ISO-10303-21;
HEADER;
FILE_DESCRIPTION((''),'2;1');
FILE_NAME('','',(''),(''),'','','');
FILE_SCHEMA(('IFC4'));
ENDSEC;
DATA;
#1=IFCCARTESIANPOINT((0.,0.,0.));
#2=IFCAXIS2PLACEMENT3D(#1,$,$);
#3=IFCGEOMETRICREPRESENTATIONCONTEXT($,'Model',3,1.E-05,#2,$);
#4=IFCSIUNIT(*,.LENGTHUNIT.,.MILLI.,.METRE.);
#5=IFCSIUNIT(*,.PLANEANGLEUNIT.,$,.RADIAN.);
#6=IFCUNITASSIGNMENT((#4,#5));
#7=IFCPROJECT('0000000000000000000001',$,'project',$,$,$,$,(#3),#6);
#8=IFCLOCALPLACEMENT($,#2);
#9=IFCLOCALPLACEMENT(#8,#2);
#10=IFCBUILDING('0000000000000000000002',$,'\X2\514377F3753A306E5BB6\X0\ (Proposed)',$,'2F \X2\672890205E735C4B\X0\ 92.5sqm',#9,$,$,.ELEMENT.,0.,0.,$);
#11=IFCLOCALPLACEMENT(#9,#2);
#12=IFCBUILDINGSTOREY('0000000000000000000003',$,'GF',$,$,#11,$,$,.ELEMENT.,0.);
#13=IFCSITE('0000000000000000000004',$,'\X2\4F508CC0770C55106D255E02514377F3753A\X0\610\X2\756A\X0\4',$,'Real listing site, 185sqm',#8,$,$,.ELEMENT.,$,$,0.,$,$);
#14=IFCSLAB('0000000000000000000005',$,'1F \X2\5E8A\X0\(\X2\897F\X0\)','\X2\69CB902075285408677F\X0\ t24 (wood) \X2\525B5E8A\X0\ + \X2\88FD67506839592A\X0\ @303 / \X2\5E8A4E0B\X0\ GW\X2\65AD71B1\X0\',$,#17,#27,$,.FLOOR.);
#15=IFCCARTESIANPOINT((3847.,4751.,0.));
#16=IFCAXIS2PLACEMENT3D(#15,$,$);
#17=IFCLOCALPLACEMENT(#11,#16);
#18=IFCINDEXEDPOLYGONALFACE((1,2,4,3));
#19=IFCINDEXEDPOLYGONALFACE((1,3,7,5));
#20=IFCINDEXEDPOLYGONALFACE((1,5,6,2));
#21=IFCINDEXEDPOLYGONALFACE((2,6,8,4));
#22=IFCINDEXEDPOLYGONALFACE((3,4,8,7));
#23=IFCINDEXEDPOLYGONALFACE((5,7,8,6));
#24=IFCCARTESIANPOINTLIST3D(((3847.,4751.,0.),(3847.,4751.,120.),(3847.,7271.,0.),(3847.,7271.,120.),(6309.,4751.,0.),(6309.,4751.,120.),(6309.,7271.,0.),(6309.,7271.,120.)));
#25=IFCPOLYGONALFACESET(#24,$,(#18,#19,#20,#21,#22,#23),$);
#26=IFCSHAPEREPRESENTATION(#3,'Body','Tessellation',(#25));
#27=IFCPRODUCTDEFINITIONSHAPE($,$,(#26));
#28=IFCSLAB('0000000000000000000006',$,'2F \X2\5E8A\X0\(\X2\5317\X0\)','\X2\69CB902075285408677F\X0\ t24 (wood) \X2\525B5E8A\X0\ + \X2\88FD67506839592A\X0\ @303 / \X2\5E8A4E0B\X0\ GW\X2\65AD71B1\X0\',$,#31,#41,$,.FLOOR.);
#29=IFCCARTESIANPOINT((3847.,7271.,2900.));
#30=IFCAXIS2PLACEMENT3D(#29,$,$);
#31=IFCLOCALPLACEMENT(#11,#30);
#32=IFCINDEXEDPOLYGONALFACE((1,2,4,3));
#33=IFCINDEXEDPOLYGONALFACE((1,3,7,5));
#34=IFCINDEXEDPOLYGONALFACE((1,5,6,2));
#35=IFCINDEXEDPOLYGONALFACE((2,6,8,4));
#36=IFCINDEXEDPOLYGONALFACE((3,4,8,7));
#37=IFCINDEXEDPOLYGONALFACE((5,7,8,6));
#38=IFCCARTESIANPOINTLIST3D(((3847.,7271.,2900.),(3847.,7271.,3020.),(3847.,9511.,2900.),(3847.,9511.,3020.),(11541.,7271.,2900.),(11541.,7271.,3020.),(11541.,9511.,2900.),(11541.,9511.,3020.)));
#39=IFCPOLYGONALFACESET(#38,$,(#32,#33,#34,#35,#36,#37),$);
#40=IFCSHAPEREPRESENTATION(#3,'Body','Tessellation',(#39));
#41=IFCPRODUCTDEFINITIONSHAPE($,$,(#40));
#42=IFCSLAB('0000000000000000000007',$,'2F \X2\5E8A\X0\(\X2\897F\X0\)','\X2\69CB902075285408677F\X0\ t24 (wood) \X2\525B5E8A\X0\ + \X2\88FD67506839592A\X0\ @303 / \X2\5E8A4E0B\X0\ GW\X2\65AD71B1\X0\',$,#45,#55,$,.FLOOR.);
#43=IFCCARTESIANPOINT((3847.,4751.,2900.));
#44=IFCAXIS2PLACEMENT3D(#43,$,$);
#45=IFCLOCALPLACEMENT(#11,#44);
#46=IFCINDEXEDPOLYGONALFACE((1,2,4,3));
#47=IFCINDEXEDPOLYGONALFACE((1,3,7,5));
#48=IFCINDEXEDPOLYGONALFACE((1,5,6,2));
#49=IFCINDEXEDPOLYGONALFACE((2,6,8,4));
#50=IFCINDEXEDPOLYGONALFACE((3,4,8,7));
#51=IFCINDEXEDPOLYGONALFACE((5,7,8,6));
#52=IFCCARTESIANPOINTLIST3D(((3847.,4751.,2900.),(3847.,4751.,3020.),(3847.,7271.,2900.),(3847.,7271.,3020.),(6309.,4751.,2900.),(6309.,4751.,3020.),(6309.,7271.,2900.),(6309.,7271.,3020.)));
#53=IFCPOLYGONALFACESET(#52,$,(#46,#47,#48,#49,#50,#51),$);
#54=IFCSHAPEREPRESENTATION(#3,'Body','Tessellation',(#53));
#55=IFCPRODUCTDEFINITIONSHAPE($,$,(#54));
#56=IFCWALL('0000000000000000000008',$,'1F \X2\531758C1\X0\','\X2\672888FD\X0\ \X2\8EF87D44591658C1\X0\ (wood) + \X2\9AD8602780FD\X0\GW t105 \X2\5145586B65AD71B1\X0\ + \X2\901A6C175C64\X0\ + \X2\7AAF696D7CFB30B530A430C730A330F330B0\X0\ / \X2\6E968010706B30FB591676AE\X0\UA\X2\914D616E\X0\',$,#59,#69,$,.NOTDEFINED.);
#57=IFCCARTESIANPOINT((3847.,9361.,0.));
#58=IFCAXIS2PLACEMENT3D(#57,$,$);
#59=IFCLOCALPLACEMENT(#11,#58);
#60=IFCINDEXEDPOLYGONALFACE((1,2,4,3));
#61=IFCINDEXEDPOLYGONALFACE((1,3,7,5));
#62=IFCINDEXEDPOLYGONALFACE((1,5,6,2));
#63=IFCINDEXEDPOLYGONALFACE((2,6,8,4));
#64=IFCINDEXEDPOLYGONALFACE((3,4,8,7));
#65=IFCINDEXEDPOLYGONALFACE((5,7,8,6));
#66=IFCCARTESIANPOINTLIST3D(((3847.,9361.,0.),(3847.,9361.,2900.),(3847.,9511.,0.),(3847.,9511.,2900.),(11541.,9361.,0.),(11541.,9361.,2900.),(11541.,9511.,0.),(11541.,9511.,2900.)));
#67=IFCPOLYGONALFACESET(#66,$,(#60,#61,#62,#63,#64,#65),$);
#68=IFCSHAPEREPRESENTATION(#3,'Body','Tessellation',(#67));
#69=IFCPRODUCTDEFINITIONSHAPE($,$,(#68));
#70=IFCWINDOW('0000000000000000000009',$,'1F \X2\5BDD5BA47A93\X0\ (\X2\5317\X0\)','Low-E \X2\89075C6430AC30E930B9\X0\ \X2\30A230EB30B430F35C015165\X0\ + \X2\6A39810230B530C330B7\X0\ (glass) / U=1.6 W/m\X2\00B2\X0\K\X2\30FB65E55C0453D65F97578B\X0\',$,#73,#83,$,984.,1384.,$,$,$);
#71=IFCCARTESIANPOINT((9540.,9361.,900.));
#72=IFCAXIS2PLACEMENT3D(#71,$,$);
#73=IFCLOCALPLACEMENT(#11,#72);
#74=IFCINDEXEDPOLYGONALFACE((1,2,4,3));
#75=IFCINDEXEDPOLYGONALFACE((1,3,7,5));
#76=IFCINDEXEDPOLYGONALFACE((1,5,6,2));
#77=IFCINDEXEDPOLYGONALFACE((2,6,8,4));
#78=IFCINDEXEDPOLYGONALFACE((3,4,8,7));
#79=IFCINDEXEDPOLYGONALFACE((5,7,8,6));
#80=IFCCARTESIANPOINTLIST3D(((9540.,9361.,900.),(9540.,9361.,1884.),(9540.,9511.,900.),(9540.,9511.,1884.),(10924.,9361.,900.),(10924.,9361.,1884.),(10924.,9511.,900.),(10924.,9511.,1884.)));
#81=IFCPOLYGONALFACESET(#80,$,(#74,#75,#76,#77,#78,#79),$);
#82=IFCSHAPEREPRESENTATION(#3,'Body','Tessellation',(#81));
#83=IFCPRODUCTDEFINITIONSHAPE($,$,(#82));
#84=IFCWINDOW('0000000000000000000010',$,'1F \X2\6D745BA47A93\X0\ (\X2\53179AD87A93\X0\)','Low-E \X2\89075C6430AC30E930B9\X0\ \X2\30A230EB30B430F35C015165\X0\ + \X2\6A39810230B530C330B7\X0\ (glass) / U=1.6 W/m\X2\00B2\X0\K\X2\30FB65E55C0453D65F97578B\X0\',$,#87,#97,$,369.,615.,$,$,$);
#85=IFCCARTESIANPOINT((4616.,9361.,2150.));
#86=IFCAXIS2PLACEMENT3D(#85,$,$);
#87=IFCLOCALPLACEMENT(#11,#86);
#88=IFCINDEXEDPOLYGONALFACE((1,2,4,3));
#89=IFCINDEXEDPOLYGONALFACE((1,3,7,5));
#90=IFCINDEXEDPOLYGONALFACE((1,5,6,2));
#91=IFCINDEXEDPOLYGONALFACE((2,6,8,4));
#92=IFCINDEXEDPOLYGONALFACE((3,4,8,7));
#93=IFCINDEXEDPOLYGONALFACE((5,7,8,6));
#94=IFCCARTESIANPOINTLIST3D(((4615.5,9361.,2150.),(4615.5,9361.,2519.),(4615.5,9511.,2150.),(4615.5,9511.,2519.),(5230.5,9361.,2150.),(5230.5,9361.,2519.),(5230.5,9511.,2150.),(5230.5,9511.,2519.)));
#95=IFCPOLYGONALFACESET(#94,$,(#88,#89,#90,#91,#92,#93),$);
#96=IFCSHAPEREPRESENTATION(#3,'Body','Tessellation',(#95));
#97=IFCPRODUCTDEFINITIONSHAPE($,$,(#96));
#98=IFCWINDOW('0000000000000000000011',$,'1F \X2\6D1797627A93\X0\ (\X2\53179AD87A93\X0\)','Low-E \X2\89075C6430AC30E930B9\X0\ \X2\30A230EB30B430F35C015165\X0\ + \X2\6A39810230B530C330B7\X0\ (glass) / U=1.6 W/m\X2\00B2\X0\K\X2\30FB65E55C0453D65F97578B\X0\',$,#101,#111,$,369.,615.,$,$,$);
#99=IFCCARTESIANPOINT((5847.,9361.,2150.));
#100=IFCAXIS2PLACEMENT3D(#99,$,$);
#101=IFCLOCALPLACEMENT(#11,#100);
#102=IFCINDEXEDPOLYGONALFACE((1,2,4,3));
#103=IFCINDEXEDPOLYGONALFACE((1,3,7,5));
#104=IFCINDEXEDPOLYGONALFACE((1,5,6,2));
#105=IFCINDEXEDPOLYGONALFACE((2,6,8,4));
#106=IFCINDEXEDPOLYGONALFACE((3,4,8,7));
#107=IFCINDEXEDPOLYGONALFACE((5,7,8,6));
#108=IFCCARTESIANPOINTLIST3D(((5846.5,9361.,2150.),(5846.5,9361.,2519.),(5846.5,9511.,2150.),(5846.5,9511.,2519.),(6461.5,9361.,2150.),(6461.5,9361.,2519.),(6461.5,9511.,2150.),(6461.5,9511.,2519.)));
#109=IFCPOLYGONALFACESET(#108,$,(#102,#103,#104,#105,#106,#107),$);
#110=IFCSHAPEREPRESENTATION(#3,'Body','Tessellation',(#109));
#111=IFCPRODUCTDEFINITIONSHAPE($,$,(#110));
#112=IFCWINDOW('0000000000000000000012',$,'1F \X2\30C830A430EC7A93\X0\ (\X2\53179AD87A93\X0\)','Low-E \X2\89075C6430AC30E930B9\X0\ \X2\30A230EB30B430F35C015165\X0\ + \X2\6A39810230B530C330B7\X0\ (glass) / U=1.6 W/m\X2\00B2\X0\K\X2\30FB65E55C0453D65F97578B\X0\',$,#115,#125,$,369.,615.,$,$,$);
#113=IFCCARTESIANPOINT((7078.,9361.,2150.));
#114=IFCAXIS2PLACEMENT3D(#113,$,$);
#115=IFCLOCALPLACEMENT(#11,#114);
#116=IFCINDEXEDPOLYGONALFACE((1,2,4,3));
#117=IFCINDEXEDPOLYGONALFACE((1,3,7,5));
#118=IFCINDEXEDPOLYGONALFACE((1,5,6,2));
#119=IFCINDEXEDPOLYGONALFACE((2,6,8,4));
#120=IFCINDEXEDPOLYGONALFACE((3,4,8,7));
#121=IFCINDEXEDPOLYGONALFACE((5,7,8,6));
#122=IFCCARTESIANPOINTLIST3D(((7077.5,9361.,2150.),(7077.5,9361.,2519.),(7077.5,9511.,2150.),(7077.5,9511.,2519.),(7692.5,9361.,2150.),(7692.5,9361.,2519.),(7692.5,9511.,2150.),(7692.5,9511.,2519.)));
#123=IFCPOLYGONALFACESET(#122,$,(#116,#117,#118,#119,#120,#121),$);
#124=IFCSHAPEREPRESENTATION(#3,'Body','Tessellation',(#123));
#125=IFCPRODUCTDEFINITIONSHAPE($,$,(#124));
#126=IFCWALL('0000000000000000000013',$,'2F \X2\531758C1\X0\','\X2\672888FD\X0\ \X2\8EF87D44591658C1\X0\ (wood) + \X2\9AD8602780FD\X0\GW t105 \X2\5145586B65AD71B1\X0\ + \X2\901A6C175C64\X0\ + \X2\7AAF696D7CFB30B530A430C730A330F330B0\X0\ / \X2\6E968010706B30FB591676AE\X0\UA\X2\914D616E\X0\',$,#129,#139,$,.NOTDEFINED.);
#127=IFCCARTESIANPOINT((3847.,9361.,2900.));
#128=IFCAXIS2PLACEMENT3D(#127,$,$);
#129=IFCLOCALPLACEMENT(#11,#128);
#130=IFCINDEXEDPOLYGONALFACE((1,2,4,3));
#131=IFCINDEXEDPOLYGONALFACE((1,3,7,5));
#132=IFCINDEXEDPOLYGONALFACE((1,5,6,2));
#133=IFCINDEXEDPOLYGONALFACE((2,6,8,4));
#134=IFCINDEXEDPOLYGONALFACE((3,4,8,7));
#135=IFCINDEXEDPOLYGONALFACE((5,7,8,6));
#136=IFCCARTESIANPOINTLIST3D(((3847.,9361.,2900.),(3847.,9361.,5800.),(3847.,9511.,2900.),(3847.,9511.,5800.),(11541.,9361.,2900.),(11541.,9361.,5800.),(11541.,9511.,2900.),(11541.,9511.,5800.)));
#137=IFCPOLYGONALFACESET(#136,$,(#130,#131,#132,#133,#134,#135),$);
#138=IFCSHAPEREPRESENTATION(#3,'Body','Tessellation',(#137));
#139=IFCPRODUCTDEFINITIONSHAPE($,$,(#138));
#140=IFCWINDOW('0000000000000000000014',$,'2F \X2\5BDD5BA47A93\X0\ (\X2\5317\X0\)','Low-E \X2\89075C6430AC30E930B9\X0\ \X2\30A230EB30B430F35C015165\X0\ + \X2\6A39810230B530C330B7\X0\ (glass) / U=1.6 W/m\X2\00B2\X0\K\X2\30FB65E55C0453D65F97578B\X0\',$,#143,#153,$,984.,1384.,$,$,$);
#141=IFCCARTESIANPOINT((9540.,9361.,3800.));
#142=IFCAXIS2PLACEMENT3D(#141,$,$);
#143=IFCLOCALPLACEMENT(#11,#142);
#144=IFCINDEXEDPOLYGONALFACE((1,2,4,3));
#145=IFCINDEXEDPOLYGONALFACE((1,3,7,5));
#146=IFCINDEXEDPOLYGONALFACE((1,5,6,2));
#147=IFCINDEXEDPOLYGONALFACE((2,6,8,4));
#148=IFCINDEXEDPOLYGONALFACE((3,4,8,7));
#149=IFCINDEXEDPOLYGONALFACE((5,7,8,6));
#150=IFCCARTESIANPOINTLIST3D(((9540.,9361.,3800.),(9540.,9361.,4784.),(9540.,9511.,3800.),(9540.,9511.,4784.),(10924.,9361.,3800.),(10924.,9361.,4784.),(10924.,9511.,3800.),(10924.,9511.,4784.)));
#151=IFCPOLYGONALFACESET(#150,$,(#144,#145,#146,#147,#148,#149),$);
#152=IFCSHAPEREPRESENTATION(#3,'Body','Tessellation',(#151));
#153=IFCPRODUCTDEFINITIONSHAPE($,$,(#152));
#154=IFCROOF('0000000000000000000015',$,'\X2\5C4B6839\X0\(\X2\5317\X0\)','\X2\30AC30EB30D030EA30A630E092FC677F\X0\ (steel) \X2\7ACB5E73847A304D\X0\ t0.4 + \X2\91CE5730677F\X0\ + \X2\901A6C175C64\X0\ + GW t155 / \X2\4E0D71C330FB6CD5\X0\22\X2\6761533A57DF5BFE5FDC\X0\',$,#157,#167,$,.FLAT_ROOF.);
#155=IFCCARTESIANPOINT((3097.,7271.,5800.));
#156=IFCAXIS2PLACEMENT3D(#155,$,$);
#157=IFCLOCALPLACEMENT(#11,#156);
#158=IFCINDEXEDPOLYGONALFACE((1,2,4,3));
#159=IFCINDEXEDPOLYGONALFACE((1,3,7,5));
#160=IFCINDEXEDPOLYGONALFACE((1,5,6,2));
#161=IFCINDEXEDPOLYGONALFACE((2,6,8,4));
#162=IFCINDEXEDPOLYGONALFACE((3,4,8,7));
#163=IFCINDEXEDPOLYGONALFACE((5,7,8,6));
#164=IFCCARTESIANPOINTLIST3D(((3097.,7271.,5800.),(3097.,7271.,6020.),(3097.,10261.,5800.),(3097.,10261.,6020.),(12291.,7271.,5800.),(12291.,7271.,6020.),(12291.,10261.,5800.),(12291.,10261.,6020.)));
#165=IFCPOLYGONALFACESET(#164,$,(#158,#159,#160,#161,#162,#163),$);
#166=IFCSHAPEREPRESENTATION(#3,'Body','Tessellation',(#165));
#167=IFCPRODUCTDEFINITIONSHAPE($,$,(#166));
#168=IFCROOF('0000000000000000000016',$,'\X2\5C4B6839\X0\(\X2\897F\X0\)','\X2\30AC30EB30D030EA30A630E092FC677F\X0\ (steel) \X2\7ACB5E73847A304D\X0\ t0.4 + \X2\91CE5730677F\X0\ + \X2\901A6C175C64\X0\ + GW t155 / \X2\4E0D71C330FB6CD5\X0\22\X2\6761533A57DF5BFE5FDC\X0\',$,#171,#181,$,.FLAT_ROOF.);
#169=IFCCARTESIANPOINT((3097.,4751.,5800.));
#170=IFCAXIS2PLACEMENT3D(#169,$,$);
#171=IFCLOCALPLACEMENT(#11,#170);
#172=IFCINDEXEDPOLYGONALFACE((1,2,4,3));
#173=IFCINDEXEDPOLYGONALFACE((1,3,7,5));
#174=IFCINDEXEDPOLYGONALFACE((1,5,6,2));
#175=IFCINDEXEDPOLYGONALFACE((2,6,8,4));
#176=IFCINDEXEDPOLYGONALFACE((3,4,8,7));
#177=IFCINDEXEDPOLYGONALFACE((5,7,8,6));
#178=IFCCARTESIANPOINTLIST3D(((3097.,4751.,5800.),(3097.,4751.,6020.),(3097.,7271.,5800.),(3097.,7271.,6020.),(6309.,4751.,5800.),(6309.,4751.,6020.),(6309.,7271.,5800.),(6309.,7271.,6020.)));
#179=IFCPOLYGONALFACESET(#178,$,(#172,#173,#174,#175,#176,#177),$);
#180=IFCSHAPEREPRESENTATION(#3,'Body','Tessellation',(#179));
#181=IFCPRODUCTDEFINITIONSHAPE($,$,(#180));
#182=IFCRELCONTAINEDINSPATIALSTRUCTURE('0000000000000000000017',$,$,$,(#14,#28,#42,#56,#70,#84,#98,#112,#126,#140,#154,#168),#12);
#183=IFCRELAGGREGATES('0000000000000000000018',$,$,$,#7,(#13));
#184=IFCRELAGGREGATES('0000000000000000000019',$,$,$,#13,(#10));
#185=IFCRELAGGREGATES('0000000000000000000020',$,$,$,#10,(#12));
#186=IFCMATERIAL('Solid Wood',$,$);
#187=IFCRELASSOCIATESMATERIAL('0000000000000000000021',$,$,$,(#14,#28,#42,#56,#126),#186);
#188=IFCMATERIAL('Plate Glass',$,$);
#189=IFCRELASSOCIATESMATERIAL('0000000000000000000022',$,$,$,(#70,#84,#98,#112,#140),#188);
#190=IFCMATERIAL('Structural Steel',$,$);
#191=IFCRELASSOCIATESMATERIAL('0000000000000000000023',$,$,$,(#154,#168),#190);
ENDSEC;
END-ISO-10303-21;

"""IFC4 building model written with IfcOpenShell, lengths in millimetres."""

from ifc_helpers import new_model, si_unit, frame, frame_2d, origin, place, context, project, spatial, rectangle, extrude, material, element, fill, save


model = new_model("IFC4")

# Units and contexts
model_context = context("Model", 3, precision=1e-05, world=origin())
ifc_project = project(units=[si_unit("LENGTHUNIT", "METRE", prefix="MILLI"), si_unit("PLANEANGLEUNIT", "RADIAN")], contexts=[model_context])

# Site, building, storey
site_placement = place(None, origin())
site = spatial("IfcSite", under=ifc_project, at=site_placement, Name="佐賀県唐津市元石町610番4", ObjectType="Real listing site, 185sqm", CompositionType="ELEMENT", RefElevation=0.0)
building_placement = place(site_placement, origin())
building = spatial("IfcBuilding", under=site, at=building_placement, Name="元石町の家 (Proposed)", ObjectType="2F 木造平屋 92.5sqm", CompositionType="ELEMENT", ElevationOfRefHeight=0.0, ElevationOfTerrain=0.0)
storey_placement = place(building_placement, origin())
storey = spatial("IfcBuildingStorey", under=building, at=storey_placement, Name="GF", CompositionType="ELEMENT", Elevation=0.0)

# Slabs
ifc_material_1 = material(Name="Solid Wood")
slab_1_placement = place(storey_placement, frame((3847.0, 4751.0, 0.0)))
element("IfcSlab", 1, at=slab_1_placement, inside=storey, material=ifc_material_1, Name="1F 床(西)", Description="構造用合板 t24 (wood) 剛床 + 製材根太 @303 / 床下 GW断熱", PredefinedType="FLOOR", context=model_context, shape_type="SweptSolid", body=[
    extrude(rectangle(XDim=2462.0, YDim=2520.0, at=frame_2d((1231.0, 1260.0))), frame((3847.0, 4751.0, 0.0)), (0.0, 0.0, 1.0), 120.0),
])
slab_2_placement = place(storey_placement, frame((3847.0, 7271.0, 2900.0)))
element("IfcSlab", 2, at=slab_2_placement, inside=storey, material=ifc_material_1, Name="2F 床(北)", Description="構造用合板 t24 (wood) 剛床 + 製材根太 @303 / 床下 GW断熱", PredefinedType="FLOOR", context=model_context, shape_type="SweptSolid", body=[
    extrude(rectangle(XDim=7694.0, YDim=2240.0, at=frame_2d((3847.0, 1120.0))), frame((3847.0, 7271.0, 2900.0)), (0.0, 0.0, 1.0), 120.0),
])
slab_3_placement = place(storey_placement, frame((3847.0, 4751.0, 2900.0)))
element("IfcSlab", 3, at=slab_3_placement, inside=storey, material=ifc_material_1, Name="2F 床(西)", Description="構造用合板 t24 (wood) 剛床 + 製材根太 @303 / 床下 GW断熱", PredefinedType="FLOOR", context=model_context, shape_type="SweptSolid", body=[
    extrude(rectangle(XDim=2462.0, YDim=2520.0, at=frame_2d((1231.0, 1260.0))), frame((3847.0, 4751.0, 2900.0)), (0.0, 0.0, 1.0), 120.0),
])

# Wall, openings, windows
wall_1_placement = place(storey_placement, frame((3847.0, 9361.0, 0.0)))
wall_1 = element("IfcWall", 4, at=wall_1_placement, inside=storey, material=ifc_material_1, Name="1F 北壁", Description="木製 軸組外壁 (wood) + 高性能GW t105 充填断熱 + 通気層 + 窯業系サイディング / 準耐火・外皮UA配慮", PredefinedType="NOTDEFINED", context=model_context, shape_type="SweptSolid", body=[
    extrude(rectangle(XDim=7694.0, YDim=150.0, at=frame_2d((3847.0, 75.0))), frame((3847.0, 9361.0, 0.0)), (0.0, 0.0, 1.0), 2900.0),
])
opening_1_placement = place(storey_placement, frame((9540.0, 9361.0, 900.0)))
opening_1 = element("IfcOpeningElement", 5, at=opening_1_placement, cuts=wall_1, PredefinedType="NOTDEFINED", context=model_context, shape_type="SweptSolid", body=[
    extrude(rectangle(XDim=1384.0, YDim=150.0, at=frame_2d((692.0, 75.0))), frame((9540.0, 9361.0, 900.0)), (0.0, 0.0, 1.0), 984.0),
])
opening_2_placement = place(storey_placement, frame((4616.0, 9361.0, 2150.0)))
opening_2 = element("IfcOpeningElement", 6, at=opening_2_placement, cuts=wall_1, PredefinedType="NOTDEFINED", context=model_context, shape_type="SweptSolid", body=[
    extrude(rectangle(XDim=615.0, YDim=150.0, at=frame_2d((307.0, 75.0))), frame((4616.0, 9361.0, 2150.0)), (0.0, 0.0, 1.0), 369.0),
])
opening_3_placement = place(storey_placement, frame((5847.0, 9361.0, 2150.0)))
opening_3 = element("IfcOpeningElement", 7, at=opening_3_placement, cuts=wall_1, PredefinedType="NOTDEFINED", context=model_context, shape_type="SweptSolid", body=[
    extrude(rectangle(XDim=615.0, YDim=150.0, at=frame_2d((307.0, 75.0))), frame((5847.0, 9361.0, 2150.0)), (0.0, 0.0, 1.0), 369.0),
])
opening_4_placement = place(storey_placement, frame((7078.0, 9361.0, 2150.0)))
opening_4 = element("IfcOpeningElement", 8, at=opening_4_placement, cuts=wall_1, PredefinedType="NOTDEFINED", context=model_context, shape_type="SweptSolid", body=[
    extrude(rectangle(XDim=615.0, YDim=150.0, at=frame_2d((307.0, 75.0))), frame((7078.0, 9361.0, 2150.0)), (0.0, 0.0, 1.0), 369.0),
])
ifc_material_2 = material(Name="Plate Glass")
window_1_placement = place(storey_placement, frame((9540.0, 9361.0, 900.0)))
window_1 = element("IfcWindow", 9, at=window_1_placement, inside=storey, material=ifc_material_2, Name="1F 寝室窓 (北)", Description="Low-E 複層ガラス アルゴン封入 + 樹脂サッシ (glass) / U=1.6 W/m²K・日射取得型", OverallHeight=984.0, OverallWidth=1384.0, context=model_context, shape_type="SweptSolid", body=[
    extrude(rectangle(XDim=1384.0, YDim=150.0, at=frame_2d((692.0, 75.0))), frame((9540.0, 9361.0, 900.0)), (0.0, 0.0, 1.0), 984.0),
])
fill(opening_1, window_1)
window_2_placement = place(storey_placement, frame((4616.0, 9361.0, 2150.0)))
window_2 = element("IfcWindow", 10, at=window_2_placement, inside=storey, material=ifc_material_2, Name="1F 浴室窓 (北高窓)", Description="Low-E 複層ガラス アルゴン封入 + 樹脂サッシ (glass) / U=1.6 W/m²K・日射取得型", OverallHeight=369.0, OverallWidth=615.0, context=model_context, shape_type="SweptSolid", body=[
    extrude(rectangle(XDim=615.0, YDim=150.0, at=frame_2d((307.0, 75.0))), frame((4616.0, 9361.0, 2150.0)), (0.0, 0.0, 1.0), 369.0),
])
fill(opening_2, window_2)
window_3_placement = place(storey_placement, frame((5847.0, 9361.0, 2150.0)))
window_3 = element("IfcWindow", 11, at=window_3_placement, inside=storey, material=ifc_material_2, Name="1F 洗面窓 (北高窓)", Description="Low-E 複層ガラス アルゴン封入 + 樹脂サッシ (glass) / U=1.6 W/m²K・日射取得型", OverallHeight=369.0, OverallWidth=615.0, context=model_context, shape_type="SweptSolid", body=[
    extrude(rectangle(XDim=615.0, YDim=150.0, at=frame_2d((307.0, 75.0))), frame((5847.0, 9361.0, 2150.0)), (0.0, 0.0, 1.0), 369.0),
])
fill(opening_3, window_3)
window_4_placement = place(storey_placement, frame((7078.0, 9361.0, 2150.0)))
window_4 = element("IfcWindow", 12, at=window_4_placement, inside=storey, material=ifc_material_2, Name="1F トイレ窓 (北高窓)", Description="Low-E 複層ガラス アルゴン封入 + 樹脂サッシ (glass) / U=1.6 W/m²K・日射取得型", OverallHeight=369.0, OverallWidth=615.0, context=model_context, shape_type="SweptSolid", body=[
    extrude(rectangle(XDim=615.0, YDim=150.0, at=frame_2d((307.0, 75.0))), frame((7078.0, 9361.0, 2150.0)), (0.0, 0.0, 1.0), 369.0),
])
fill(opening_4, window_4)

# Wall, opening, window
wall_2_placement = place(storey_placement, frame((3847.0, 9361.0, 2900.0)))
wall_2 = element("IfcWall", 13, at=wall_2_placement, inside=storey, material=ifc_material_1, Name="2F 北壁", Description="木製 軸組外壁 (wood) + 高性能GW t105 充填断熱 + 通気層 + 窯業系サイディング / 準耐火・外皮UA配慮", PredefinedType="NOTDEFINED", context=model_context, shape_type="SweptSolid", body=[
    extrude(rectangle(XDim=7694.0, YDim=150.0, at=frame_2d((3847.0, 75.0))), frame((3847.0, 9361.0, 2900.0)), (0.0, 0.0, 1.0), 2900.0),
])
opening_5_placement = place(storey_placement, frame((9540.0, 9361.0, 3800.0)))
opening_5 = element("IfcOpeningElement", 14, at=opening_5_placement, cuts=wall_2, PredefinedType="NOTDEFINED", context=model_context, shape_type="SweptSolid", body=[
    extrude(rectangle(XDim=1384.0, YDim=150.0, at=frame_2d((692.0, 75.0))), frame((9540.0, 9361.0, 3800.0)), (0.0, 0.0, 1.0), 984.0),
])
window_5_placement = place(storey_placement, frame((9540.0, 9361.0, 3800.0)))
window_5 = element("IfcWindow", 15, at=window_5_placement, inside=storey, material=ifc_material_2, Name="2F 寝室窓 (北)", Description="Low-E 複層ガラス アルゴン封入 + 樹脂サッシ (glass) / U=1.6 W/m²K・日射取得型", OverallHeight=984.0, OverallWidth=1384.0, context=model_context, shape_type="SweptSolid", body=[
    extrude(rectangle(XDim=1384.0, YDim=150.0, at=frame_2d((692.0, 75.0))), frame((9540.0, 9361.0, 3800.0)), (0.0, 0.0, 1.0), 984.0),
])
fill(opening_5, window_5)

# Roofs
ifc_material_3 = material(Name="Structural Steel")
for number, where, name in (
    (16, (3097.0, 7271.0, 5800.0), "屋根(北)"),
):
    element("IfcRoof", number, at=place(storey_placement, frame(where)), inside=storey, material=ifc_material_3, Name=name, Description="ガルバリウム鋼板 (steel) 立平葺き t0.4 + 野地板 + 通気層 + GW t155 / 不燃・法22条区域対応", PredefinedType="FLAT_ROOF", context=model_context, shape_type="SweptSolid", body=[
        extrude(rectangle(XDim=9194.0, YDim=2990.0, at=frame_2d((4597.0, 1495.0))), frame((3097.0, 7271.0, 5800.0)), (0.0, 0.0, 1.0), 220.0),
    ])
roof_placement = place(storey_placement, frame((3097.0, 4751.0, 5800.0)))
element("IfcRoof", 17, at=roof_placement, inside=storey, material=ifc_material_3, Name="屋根(西)", Description="ガルバリウム鋼板 (steel) 立平葺き t0.4 + 野地板 + 通気層 + GW t155 / 不燃・法22条区域対応", PredefinedType="FLAT_ROOF", context=model_context, shape_type="SweptSolid", body=[
    extrude(rectangle(XDim=3212.0, YDim=2520.0, at=frame_2d((1606.0, 1260.0))), frame((3097.0, 4751.0, 5800.0)), (0.0, 0.0, 1.0), 220.0),
])

save(model, "model.ifc")
